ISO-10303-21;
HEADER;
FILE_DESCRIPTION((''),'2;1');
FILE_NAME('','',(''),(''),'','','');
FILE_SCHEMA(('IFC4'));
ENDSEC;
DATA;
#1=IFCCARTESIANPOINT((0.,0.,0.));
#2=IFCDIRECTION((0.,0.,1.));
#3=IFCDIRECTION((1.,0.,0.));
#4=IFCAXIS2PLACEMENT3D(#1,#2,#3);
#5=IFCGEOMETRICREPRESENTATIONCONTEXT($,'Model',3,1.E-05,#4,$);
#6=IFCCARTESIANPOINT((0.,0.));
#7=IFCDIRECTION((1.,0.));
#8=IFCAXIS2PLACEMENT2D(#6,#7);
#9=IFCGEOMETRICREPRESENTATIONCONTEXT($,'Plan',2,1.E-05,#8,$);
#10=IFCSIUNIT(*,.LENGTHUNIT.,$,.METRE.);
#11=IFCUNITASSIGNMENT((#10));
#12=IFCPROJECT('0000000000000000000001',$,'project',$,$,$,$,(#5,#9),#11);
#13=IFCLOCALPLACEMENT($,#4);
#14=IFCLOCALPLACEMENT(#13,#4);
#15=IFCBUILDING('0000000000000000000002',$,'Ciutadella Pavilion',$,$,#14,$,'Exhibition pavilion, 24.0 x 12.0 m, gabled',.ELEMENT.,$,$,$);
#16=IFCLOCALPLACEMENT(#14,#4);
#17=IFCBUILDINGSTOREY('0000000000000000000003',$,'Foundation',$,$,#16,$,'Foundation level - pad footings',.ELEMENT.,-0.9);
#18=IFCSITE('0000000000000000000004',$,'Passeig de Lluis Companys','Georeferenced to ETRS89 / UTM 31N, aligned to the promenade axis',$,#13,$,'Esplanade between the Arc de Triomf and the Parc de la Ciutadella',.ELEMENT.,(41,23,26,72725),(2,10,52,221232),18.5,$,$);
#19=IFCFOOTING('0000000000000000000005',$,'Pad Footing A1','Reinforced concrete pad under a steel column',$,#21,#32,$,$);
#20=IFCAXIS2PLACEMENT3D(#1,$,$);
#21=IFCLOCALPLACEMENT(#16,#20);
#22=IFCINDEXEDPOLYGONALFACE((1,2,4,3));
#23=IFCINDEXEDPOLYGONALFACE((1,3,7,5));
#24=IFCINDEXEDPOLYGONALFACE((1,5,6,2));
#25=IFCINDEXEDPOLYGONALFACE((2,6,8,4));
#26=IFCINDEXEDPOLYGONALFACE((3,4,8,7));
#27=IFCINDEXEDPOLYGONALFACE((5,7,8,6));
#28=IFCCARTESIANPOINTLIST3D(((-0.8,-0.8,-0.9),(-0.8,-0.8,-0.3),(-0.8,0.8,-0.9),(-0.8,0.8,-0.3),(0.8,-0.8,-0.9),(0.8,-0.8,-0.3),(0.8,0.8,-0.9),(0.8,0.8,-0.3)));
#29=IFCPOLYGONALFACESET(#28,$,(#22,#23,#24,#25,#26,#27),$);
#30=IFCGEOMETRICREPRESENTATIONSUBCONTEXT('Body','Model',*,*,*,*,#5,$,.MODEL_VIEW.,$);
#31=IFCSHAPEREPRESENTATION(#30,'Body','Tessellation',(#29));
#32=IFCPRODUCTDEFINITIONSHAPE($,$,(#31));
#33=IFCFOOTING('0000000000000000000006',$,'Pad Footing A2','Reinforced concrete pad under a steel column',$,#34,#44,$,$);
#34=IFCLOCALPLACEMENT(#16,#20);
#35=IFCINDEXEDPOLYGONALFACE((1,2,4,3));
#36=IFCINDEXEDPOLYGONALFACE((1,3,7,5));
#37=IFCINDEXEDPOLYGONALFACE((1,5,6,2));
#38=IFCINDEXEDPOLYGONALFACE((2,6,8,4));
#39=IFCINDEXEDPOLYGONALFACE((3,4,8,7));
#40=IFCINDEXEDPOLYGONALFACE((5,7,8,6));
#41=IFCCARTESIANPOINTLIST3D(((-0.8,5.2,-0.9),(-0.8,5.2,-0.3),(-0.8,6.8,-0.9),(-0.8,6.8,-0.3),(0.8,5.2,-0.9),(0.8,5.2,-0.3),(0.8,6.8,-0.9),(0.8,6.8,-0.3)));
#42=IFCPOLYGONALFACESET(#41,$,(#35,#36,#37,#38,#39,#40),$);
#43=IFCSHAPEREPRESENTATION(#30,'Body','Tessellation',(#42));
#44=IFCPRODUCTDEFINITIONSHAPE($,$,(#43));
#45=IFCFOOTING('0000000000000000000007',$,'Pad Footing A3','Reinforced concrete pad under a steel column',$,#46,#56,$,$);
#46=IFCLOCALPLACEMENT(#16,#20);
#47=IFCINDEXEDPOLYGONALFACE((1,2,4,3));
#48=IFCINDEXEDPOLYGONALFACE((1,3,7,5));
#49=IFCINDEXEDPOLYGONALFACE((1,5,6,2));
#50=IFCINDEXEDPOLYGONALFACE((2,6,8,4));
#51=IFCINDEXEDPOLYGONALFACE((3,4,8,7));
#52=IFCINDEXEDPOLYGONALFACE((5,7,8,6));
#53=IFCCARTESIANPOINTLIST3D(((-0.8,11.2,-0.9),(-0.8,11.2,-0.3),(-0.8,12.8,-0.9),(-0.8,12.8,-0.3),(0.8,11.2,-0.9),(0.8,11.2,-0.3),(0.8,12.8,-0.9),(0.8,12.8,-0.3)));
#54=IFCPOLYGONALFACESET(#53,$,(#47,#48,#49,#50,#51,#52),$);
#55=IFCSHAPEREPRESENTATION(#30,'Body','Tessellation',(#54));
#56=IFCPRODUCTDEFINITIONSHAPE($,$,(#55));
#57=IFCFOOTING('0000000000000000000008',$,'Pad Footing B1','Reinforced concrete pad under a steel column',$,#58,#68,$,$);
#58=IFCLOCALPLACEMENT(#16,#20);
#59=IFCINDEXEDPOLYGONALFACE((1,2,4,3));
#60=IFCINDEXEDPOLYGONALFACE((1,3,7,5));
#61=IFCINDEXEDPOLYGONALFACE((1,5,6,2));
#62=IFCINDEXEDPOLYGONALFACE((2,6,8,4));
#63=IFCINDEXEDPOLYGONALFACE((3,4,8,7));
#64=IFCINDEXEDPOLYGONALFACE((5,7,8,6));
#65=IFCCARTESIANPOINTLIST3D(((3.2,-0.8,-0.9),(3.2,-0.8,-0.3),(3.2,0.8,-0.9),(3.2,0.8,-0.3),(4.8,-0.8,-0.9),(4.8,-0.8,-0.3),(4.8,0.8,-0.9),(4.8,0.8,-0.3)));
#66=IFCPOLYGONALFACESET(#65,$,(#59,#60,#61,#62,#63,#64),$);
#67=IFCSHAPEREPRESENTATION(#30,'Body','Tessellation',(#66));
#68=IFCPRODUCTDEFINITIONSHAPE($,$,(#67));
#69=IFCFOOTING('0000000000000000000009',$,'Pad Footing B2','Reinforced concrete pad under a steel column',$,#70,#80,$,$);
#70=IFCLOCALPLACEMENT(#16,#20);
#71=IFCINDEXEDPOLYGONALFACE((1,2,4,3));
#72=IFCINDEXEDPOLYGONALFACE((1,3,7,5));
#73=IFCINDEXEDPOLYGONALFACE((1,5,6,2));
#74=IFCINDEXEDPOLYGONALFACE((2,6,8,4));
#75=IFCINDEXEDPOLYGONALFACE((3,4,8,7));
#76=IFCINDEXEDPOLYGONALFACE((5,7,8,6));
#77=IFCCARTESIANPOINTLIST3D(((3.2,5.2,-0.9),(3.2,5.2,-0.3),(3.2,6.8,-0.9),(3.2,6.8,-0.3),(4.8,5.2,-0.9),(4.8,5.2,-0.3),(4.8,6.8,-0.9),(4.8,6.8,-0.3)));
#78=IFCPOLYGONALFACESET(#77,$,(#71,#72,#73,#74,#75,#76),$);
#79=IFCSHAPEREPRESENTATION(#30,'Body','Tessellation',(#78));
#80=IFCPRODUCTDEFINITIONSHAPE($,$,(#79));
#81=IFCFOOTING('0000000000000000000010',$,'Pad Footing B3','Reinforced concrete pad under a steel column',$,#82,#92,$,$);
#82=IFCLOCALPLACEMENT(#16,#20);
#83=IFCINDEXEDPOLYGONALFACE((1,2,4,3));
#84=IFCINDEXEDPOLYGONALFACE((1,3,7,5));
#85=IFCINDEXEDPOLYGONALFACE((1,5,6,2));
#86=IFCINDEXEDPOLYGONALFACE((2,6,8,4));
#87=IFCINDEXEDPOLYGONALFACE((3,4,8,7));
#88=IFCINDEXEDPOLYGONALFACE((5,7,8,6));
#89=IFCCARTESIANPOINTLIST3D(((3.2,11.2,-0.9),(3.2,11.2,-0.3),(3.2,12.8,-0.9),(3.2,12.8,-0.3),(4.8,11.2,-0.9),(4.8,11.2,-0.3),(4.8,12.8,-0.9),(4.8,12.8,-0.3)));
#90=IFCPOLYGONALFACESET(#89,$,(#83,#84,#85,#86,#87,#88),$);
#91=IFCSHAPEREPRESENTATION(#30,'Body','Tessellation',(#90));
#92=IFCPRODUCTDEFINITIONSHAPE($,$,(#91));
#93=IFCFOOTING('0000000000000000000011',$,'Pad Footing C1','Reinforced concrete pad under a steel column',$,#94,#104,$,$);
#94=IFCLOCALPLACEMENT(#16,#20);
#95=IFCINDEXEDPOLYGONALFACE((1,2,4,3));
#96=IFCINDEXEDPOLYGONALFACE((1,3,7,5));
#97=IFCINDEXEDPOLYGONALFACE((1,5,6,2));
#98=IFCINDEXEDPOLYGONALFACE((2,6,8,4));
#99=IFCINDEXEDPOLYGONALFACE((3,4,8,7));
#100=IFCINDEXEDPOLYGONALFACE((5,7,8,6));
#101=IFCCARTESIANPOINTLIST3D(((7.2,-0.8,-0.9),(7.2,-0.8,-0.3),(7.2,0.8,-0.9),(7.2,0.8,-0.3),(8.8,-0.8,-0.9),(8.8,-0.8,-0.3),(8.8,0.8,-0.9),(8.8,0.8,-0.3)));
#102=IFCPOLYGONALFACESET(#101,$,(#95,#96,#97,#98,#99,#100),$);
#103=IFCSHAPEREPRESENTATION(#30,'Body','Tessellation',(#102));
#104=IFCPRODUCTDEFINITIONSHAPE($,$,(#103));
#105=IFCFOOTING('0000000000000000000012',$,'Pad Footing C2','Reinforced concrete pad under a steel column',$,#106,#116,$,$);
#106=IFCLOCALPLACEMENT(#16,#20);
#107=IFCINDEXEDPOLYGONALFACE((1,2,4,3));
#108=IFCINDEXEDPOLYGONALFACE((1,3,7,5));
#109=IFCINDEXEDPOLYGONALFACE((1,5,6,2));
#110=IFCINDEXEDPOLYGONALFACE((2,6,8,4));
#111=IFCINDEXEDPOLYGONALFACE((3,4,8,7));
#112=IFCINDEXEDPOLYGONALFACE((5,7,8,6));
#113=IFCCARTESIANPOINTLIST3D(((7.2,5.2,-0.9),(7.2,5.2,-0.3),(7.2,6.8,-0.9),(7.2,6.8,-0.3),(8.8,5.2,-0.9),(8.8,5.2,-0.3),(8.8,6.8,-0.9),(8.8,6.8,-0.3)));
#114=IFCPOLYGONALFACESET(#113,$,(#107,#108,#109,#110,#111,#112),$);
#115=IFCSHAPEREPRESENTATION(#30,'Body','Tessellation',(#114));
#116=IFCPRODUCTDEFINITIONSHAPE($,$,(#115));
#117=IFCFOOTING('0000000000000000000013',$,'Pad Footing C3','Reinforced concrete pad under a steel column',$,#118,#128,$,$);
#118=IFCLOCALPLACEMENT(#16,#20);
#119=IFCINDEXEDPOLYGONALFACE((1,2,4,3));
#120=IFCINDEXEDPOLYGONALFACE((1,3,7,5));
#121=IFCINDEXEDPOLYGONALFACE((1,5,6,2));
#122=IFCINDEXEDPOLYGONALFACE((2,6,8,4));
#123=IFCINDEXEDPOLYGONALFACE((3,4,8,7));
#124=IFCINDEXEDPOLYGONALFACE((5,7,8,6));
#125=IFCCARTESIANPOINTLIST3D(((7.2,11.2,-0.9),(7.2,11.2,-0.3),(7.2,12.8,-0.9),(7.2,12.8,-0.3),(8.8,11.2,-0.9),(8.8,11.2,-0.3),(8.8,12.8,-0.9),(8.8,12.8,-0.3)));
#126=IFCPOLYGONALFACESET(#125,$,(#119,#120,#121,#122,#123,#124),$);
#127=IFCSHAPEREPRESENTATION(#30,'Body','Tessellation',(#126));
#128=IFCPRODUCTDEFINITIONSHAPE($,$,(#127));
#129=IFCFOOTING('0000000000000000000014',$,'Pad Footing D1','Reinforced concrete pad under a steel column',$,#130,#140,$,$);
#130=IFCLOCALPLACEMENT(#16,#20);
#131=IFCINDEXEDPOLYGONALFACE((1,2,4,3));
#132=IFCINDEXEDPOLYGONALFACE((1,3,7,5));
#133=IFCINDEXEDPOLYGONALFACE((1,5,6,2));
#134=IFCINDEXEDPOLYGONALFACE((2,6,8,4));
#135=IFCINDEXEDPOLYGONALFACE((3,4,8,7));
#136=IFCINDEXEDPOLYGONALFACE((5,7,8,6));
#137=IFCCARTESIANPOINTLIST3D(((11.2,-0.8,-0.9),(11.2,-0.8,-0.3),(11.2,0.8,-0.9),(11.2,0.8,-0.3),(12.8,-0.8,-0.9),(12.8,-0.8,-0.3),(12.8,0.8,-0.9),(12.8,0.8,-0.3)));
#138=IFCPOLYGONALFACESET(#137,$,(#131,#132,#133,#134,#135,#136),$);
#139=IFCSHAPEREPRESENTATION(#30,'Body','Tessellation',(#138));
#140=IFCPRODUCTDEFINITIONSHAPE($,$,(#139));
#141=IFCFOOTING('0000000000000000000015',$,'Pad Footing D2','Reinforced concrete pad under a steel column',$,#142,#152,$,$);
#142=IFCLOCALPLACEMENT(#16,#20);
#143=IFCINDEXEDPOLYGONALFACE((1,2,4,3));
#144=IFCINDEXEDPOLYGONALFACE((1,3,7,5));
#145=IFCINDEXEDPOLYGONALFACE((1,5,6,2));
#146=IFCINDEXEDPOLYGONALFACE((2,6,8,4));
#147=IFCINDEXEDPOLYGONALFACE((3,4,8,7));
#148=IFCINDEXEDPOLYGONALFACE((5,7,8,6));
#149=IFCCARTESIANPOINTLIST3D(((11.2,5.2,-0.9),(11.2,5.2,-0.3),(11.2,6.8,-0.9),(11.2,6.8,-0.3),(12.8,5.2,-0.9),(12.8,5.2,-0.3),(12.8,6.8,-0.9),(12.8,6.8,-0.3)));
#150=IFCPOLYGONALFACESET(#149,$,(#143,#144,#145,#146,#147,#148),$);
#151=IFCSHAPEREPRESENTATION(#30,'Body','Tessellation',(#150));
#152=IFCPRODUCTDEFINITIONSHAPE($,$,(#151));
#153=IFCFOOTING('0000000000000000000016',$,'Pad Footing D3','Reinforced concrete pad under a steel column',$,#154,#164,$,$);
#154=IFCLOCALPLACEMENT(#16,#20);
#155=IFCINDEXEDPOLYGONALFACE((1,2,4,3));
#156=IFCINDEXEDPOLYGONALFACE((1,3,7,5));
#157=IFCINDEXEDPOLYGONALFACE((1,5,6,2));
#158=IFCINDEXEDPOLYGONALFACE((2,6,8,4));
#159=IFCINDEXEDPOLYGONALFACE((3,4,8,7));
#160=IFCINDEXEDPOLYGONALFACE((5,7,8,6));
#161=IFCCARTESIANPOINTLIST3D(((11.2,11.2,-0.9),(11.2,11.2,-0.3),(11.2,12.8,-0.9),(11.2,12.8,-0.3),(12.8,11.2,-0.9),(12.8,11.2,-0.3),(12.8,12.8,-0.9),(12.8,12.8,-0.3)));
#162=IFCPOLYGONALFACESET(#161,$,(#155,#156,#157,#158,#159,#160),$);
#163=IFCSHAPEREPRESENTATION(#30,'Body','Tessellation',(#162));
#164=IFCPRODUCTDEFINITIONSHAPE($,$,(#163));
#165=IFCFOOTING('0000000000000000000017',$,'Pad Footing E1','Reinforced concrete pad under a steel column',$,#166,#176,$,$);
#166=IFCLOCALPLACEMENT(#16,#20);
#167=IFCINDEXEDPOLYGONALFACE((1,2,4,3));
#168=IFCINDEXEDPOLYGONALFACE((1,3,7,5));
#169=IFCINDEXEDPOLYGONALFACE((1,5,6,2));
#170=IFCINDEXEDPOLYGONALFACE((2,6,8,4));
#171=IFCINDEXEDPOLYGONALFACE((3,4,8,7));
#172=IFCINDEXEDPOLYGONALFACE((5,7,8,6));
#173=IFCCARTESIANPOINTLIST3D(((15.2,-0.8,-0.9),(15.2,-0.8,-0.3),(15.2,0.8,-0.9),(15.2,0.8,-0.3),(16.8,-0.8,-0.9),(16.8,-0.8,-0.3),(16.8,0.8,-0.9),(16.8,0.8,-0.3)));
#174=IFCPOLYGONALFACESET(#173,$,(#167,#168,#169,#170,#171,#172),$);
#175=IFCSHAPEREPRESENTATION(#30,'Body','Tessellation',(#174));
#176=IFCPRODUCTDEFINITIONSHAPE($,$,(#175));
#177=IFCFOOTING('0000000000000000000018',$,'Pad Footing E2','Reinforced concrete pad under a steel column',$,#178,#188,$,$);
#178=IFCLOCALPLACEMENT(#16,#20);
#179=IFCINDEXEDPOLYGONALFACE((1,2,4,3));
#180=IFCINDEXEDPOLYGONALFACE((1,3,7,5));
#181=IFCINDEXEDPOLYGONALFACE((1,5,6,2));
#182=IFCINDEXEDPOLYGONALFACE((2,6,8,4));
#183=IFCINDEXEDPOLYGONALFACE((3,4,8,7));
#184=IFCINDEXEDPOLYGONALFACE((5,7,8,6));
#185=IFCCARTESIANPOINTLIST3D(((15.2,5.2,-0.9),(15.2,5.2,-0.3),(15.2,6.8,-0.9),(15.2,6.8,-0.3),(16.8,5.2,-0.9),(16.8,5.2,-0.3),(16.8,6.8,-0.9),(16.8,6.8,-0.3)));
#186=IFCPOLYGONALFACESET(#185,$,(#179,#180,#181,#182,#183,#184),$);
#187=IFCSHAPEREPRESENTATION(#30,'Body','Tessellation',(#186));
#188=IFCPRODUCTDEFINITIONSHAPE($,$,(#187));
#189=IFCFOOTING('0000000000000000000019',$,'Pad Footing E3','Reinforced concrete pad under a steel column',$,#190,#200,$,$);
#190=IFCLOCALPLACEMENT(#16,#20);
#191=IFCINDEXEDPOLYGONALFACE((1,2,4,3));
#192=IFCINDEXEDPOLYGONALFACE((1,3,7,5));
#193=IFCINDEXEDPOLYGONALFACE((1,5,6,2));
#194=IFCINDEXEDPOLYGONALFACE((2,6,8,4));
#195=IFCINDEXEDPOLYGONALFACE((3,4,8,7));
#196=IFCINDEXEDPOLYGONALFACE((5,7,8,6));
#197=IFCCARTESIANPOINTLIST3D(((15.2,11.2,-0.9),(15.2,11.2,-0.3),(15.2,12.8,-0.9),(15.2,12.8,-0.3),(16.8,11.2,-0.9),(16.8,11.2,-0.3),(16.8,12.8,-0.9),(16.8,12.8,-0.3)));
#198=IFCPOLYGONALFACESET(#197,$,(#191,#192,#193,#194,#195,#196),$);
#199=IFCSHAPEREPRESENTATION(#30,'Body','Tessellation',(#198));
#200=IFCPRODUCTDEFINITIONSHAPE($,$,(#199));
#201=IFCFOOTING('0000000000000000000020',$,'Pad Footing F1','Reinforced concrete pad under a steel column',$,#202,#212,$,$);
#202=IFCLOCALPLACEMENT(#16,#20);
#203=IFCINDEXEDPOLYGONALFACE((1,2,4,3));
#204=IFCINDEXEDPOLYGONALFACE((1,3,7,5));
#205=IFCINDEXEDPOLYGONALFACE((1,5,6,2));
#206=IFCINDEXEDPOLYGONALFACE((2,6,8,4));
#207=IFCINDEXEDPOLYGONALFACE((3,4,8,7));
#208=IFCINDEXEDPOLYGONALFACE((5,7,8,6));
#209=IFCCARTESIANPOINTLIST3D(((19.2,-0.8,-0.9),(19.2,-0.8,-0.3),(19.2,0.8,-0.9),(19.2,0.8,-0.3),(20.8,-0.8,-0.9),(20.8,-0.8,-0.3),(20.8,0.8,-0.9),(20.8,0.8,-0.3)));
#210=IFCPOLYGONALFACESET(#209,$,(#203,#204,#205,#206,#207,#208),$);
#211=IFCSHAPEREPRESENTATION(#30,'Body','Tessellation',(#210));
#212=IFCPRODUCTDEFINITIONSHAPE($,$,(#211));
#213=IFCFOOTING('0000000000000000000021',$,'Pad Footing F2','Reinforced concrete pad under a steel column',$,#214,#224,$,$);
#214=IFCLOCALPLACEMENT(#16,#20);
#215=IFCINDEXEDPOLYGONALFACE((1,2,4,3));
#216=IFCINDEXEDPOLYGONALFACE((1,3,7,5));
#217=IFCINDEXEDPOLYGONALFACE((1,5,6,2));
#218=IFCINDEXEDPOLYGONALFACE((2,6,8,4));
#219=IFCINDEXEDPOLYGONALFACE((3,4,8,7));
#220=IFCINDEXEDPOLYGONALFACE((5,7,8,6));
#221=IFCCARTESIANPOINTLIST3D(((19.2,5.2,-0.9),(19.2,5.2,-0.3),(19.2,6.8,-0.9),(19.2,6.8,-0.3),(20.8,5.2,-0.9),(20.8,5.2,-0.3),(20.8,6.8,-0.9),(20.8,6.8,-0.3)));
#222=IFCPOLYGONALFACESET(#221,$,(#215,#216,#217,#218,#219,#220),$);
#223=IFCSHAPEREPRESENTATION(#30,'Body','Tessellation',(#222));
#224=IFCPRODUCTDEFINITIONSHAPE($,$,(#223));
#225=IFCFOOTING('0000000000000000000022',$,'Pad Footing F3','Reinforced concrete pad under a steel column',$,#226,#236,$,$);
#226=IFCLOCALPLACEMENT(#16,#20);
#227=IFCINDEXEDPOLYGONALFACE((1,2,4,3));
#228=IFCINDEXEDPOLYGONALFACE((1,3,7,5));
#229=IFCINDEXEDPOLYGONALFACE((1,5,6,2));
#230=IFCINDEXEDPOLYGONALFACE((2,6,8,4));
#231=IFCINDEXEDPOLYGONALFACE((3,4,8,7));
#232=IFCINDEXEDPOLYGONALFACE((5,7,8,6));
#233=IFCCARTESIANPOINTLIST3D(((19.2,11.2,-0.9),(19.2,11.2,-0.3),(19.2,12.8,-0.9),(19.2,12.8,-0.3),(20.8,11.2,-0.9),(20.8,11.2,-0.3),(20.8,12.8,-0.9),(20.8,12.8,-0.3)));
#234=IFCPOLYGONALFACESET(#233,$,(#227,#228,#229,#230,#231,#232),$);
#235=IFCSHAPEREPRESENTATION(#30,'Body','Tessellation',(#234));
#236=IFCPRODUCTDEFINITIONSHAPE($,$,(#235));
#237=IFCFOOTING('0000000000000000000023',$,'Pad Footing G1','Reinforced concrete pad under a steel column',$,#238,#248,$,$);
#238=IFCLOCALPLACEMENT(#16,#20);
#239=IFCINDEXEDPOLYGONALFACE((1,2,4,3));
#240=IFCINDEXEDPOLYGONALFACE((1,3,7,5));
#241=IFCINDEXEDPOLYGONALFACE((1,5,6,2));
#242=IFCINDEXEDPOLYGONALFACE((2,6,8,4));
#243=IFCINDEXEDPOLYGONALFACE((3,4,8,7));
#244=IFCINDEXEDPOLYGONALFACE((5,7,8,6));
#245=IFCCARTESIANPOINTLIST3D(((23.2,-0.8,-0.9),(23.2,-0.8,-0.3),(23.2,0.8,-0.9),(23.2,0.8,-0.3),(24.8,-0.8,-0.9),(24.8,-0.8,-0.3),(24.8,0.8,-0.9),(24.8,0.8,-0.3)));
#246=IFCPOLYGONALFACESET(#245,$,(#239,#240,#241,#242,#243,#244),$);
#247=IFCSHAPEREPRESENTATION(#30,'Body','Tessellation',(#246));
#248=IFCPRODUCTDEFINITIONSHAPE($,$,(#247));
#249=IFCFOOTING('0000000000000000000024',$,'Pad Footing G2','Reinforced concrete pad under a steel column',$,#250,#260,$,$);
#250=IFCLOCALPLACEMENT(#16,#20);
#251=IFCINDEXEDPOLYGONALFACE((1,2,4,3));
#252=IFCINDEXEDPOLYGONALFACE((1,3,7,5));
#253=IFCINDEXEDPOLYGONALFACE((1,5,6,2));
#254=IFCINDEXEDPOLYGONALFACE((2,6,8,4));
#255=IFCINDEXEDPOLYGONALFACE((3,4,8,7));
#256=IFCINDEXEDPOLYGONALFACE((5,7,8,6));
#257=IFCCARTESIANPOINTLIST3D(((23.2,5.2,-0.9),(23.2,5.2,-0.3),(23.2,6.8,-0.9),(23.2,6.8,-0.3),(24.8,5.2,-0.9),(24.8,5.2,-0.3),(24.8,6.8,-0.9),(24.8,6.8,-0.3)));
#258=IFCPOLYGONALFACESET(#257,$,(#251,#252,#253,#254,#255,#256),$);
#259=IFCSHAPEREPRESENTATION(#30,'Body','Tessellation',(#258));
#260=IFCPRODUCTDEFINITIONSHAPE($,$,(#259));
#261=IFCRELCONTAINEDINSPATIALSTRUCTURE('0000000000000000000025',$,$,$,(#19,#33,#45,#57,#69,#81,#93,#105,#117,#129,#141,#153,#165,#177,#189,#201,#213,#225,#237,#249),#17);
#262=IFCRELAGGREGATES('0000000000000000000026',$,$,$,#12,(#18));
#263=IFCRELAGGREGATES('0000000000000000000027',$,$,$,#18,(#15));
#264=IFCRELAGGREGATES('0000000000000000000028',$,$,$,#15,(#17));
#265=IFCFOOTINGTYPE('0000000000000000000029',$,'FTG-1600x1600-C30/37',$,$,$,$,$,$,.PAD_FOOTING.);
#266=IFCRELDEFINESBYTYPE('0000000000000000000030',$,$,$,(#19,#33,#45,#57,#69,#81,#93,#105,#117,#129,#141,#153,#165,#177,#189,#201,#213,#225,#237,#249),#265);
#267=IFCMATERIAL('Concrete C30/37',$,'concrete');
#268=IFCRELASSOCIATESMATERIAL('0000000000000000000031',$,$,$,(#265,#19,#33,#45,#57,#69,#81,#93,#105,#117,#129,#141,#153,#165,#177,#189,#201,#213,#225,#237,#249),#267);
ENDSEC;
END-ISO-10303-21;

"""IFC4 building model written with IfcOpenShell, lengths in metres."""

from ifc_helpers import new_model, si_unit, frame, origin_with_axes, origin_2d_with_axis, place, context, subcontext, project, spatial, line, indexed_curve, outline, extrude, material, type_object, element, save


model = new_model("IFC4")

# Units and contexts
model_context = context("Model", 3, precision=1e-05, world=origin_with_axes())
plan_context = context("Plan", 2, precision=1e-05, world=origin_2d_with_axis())
body_context = subcontext(model_context, "Body", "Model", "MODEL_VIEW")
ifc_project = project(units=[si_unit("LENGTHUNIT", "METRE")], contexts=[model_context, plan_context])

# Site, building, storey
site_placement = place(None, origin_with_axes())
site = spatial("IfcSite", under=ifc_project, at=site_placement, Name="Passeig de Lluis Companys", Description="Georeferenced to ETRS89 / UTM 31N, aligned to the promenade axis", LongName="Esplanade between the Arc de Triomf and the Parc de la Ciutadella", CompositionType="ELEMENT", RefLatitude=(41, 23, 26, 72725), RefLongitude=(2, 10, 52, 221232), RefElevation=18.5)
building_placement = place(site_placement, origin_with_axes())
building = spatial("IfcBuilding", under=site, at=building_placement, Name="Ciutadella Pavilion", LongName="Exhibition pavilion, 24.0 x 12.0 m, gabled", CompositionType="ELEMENT")
storey_placement = place(building_placement, origin_with_axes())
storey = spatial("IfcBuildingStorey", under=building, at=storey_placement, Name="Foundation", LongName="Foundation level - pad footings", CompositionType="ELEMENT", Elevation=-0.9)

# Footings
ifc_material = material(Name="Concrete C30/37", Category="concrete")
footing_type = type_object("IfcFootingType", Name="FTG-1600x1600-C30/37", PredefinedType="PAD_FOOTING", material=ifc_material)
for number, where, z_axis, x_axis, name in (
    (1, (-0.8, -0.8, -0.9), (0.0, 0.0, 1.0), (1.0, 0.0, 0.0), "Pad Footing A1"),
    (2, (-0.8, 5.2, -0.9), (0.0, 0.0, 1.0), (1.0, 0.0, 0.0), "Pad Footing A2"),
    (3, (-0.8, 11.2, -0.9), (0.0, 0.0, 1.0), (1.0, 0.0, 0.0), "Pad Footing A3"),
    (4, (3.2, -0.8, -0.9), (0.0, 0.0, 1.0), (1.0, 0.0, 0.0), "Pad Footing B1"),
    (5, (3.2, 5.2, -0.9), (0.0, 0.0, 1.0), (1.0, 0.0, 0.0), "Pad Footing B2"),
    (6, (3.2, 11.2, -0.9), (0.0, 0.0, 1.0), (1.0, 0.0, 0.0), "Pad Footing B3"),
    (7, (7.2, -0.8, -0.9), (0.0, 0.0, 1.0), (1.0, 0.0, 0.0), "Pad Footing C1"),
    (8, (7.2, 5.2, -0.9), (0.0, 0.0, 1.0), (1.0, 0.0, 0.0), "Pad Footing C2"),
    (9, (7.2, 11.2, -0.9), (0.0, 0.0, 1.0), (1.0, 0.0, 0.0), "Pad Footing C3"),
    (10, (11.2, -0.8, -0.9), (0.0, 0.0, 1.0), (1.0, 0.0, 0.0), "Pad Footing D1"),
    (11, (11.2, 5.2, -0.9), (0.0, 0.0, 1.0), (1.0, 0.0, 0.0), "Pad Footing D2"),
    (12, (11.2, 11.2, -0.9), (0.0, 0.0, 1.0), (1.0, 0.0, 0.0), "Pad Footing D3"),
    (13, (15.2, -0.8, -0.9), (0.0, 0.0, 1.0), (1.0, 0.0, 0.0), "Pad Footing E1"),
    (14, (15.2, 5.2, -0.9), (0.0, 0.0, 1.0), (1.0, 0.0, 0.0), "Pad Footing E2"),
    (15, (15.2, 11.2, -0.9), (0.0, 0.0, 1.0), (1.0, 0.0, 0.0), "Pad Footing E3"),
    (16, (19.2, -0.8, -0.9), (0.0, 0.0, 1.0), (1.0, 0.0, 0.0), "Pad Footing F1"),
    (17, (19.2, 5.2, -0.9), (0.0, 0.0, 1.0), (1.0, 0.0, 0.0), "Pad Footing F2"),
    (18, (19.2, 11.2, -0.9), (0.0, 0.0, 1.0), (1.0, 0.0, 0.0), "Pad Footing F3"),
    (19, (23.2, -0.8, -0.9), (0.0, 0.0, 1.0), (1.0, 0.0, 0.0), "Pad Footing G1"),
    (20, (23.2, 5.2, -0.9), (0.0, 0.0, 1.0), (1.0, 0.0, 0.0), "Pad Footing G2"),
):
    element("IfcFooting", number, at=place(storey_placement, frame(where, z_axis=z_axis, x_axis=x_axis)), inside=storey, type_object=footing_type, material=ifc_material, Name=name, Description="Reinforced concrete pad under a steel column", context=body_context, shape_type="SweptSolid", body=[
        extrude(outline(indexed_curve([(0.0, 0.0), (1.6, 0.0), (1.6, 1.6), (0.0, 1.6)], segments=[line(1, 2, 3, 4, 1)])), origin_with_axes(), (0.0, 0.0, 1.0), 0.6),
    ])

save(model, "model.ifc")
